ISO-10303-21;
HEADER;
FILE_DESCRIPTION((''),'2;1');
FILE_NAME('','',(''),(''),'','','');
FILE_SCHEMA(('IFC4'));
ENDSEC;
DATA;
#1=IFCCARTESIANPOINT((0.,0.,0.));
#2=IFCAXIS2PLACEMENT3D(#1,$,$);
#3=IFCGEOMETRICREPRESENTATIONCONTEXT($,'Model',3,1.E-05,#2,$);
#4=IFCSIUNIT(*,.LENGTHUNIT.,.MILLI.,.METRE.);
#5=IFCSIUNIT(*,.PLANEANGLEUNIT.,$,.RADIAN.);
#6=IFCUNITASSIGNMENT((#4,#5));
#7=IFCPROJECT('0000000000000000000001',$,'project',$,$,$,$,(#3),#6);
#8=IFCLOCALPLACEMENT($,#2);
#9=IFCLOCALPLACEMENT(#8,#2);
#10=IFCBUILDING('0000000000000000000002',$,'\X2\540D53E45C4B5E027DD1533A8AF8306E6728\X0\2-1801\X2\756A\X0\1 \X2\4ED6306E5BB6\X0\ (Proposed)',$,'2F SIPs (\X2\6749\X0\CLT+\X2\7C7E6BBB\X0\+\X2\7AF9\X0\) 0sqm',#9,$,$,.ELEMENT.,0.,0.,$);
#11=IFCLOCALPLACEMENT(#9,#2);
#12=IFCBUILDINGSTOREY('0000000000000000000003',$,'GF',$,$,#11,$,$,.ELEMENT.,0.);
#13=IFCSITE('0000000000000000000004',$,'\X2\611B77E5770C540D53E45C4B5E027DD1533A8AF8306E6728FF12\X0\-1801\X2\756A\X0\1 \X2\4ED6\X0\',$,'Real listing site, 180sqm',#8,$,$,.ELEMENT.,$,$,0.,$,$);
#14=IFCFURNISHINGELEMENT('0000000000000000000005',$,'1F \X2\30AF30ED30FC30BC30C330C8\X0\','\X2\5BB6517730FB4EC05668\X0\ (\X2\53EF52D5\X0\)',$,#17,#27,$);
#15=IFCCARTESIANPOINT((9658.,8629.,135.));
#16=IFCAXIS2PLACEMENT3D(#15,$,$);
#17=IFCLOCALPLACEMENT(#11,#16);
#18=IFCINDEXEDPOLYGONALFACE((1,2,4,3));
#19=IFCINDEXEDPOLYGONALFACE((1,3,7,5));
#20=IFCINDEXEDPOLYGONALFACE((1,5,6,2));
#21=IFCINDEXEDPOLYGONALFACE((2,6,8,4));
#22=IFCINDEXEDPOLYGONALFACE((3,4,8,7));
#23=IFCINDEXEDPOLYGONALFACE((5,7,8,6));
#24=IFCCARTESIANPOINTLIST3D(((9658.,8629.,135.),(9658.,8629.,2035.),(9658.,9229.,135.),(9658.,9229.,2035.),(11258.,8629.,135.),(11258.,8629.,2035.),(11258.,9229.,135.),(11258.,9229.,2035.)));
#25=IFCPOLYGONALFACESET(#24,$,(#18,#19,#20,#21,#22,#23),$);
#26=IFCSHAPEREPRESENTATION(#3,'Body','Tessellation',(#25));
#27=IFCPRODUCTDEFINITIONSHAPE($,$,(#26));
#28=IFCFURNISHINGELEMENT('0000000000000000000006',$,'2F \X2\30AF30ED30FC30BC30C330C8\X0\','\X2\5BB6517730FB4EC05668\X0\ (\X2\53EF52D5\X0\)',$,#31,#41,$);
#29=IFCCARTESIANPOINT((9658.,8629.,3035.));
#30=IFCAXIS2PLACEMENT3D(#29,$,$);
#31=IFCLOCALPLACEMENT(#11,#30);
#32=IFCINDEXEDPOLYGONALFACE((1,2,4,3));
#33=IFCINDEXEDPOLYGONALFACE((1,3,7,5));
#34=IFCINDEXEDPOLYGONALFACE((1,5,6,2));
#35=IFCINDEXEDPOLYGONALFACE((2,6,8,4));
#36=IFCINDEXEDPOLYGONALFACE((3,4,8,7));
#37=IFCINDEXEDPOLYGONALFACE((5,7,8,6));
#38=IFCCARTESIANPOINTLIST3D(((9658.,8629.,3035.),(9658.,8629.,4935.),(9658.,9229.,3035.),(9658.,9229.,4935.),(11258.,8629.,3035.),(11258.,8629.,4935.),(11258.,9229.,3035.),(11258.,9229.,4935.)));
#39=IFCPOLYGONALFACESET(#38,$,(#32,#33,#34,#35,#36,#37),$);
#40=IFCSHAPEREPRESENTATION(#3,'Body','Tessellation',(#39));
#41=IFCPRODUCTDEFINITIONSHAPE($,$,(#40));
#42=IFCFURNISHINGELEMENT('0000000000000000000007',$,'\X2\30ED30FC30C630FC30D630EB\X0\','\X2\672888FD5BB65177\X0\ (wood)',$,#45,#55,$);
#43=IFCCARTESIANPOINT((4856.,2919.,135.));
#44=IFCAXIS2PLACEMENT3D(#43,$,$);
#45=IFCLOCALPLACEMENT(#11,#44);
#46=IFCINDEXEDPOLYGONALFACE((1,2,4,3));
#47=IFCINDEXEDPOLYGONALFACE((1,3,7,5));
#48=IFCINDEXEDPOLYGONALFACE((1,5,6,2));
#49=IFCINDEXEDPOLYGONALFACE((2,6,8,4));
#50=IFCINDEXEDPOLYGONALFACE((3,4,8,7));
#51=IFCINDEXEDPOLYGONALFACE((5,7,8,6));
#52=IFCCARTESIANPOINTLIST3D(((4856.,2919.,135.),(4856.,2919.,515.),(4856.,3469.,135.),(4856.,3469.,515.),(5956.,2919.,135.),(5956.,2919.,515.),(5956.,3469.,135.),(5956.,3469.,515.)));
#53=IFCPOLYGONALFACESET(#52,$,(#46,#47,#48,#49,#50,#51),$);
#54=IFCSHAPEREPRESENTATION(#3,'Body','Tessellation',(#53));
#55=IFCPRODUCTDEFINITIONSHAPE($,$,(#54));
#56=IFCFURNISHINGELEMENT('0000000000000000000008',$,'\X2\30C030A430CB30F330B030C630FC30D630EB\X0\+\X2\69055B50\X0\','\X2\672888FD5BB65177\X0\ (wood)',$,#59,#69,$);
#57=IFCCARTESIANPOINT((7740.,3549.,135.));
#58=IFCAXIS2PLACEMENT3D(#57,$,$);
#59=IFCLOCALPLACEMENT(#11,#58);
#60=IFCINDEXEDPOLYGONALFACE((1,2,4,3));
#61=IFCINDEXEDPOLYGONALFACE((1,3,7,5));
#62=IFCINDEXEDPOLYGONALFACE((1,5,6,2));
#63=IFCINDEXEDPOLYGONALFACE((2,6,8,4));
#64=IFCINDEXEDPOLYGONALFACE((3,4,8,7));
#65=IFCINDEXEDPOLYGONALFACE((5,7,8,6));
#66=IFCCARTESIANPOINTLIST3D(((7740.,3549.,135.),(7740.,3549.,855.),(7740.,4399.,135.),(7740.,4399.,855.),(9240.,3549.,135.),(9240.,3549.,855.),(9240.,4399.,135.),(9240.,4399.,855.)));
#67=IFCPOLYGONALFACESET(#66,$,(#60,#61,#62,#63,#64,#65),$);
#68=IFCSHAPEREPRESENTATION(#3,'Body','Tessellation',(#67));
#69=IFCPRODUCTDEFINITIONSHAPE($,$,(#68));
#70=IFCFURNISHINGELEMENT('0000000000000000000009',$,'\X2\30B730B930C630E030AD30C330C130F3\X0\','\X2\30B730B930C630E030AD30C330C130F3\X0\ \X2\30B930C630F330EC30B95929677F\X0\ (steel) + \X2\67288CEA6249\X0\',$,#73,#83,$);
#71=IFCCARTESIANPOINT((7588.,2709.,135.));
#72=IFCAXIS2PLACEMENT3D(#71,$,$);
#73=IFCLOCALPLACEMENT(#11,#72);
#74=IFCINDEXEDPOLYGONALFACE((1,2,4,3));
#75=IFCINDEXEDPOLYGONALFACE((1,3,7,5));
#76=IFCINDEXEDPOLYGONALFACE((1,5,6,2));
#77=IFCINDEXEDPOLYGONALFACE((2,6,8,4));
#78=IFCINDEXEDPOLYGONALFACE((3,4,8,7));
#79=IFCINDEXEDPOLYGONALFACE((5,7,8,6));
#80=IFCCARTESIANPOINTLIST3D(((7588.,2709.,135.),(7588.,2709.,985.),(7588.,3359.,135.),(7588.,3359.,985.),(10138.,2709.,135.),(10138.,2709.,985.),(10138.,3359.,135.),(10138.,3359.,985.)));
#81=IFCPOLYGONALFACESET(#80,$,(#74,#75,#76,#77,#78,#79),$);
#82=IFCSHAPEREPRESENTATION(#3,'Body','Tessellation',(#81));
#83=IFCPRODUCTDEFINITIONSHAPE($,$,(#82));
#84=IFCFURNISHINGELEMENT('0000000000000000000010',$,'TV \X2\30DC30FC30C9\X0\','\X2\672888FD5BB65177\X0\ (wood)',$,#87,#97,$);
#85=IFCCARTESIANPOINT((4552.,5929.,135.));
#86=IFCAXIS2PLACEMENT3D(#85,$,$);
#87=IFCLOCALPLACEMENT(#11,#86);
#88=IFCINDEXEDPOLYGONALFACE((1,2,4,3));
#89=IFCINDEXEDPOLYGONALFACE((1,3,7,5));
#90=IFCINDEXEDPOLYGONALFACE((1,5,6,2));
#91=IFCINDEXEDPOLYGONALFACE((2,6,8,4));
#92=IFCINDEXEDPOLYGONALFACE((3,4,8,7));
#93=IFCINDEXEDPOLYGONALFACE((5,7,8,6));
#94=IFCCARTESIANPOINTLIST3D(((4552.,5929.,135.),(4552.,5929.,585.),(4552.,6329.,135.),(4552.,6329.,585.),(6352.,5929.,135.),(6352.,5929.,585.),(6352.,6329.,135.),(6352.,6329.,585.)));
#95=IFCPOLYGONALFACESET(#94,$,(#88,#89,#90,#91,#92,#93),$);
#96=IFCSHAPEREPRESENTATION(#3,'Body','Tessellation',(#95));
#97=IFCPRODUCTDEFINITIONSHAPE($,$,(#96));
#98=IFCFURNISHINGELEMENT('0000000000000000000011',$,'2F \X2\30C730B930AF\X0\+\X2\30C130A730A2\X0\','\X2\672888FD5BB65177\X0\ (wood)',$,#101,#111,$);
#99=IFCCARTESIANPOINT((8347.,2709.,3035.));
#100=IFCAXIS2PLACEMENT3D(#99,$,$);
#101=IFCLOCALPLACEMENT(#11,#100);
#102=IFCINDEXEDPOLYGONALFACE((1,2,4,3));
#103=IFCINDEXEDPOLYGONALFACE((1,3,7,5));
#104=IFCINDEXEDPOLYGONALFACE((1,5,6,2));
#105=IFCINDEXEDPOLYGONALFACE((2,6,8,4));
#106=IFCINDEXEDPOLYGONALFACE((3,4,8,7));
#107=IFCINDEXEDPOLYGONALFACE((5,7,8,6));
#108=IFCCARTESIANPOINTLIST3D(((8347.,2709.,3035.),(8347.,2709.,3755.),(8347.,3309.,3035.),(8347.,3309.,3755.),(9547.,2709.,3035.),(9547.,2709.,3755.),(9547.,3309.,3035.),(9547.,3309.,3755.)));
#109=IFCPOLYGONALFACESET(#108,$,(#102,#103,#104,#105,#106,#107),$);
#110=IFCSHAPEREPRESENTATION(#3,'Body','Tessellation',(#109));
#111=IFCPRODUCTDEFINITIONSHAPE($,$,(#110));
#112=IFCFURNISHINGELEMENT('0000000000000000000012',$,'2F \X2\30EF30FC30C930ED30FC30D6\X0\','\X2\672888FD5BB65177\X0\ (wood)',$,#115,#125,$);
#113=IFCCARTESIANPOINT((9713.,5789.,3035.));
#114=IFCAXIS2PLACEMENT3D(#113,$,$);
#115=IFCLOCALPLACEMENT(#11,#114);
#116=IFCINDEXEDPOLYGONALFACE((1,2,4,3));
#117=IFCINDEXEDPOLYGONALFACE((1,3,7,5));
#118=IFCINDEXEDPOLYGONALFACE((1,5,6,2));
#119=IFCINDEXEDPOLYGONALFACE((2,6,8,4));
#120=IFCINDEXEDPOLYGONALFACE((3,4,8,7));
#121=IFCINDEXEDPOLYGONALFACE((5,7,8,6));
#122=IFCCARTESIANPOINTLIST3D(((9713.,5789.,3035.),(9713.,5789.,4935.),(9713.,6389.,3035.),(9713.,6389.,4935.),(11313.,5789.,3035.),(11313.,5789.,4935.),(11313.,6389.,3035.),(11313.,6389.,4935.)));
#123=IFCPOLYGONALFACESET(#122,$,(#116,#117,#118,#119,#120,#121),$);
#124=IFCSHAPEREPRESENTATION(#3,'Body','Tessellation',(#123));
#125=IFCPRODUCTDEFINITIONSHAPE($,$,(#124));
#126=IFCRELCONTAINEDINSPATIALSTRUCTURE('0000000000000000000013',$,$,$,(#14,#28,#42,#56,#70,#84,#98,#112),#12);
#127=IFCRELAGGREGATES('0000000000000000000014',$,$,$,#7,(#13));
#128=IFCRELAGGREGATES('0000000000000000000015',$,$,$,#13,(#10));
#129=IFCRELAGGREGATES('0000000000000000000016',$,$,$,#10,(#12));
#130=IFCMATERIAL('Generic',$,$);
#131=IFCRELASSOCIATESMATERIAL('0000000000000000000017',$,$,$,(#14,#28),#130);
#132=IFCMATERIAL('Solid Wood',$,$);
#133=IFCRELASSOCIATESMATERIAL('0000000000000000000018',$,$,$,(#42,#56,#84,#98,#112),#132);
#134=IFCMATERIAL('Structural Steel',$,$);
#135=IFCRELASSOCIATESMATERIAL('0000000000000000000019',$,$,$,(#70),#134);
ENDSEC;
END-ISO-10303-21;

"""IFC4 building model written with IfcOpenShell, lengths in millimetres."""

from ifc_helpers import new_model, si_unit, frame, frame_2d, origin, place, context, project, spatial, rectangle, extrude, material, element, save


model = new_model("IFC4")

# Units and contexts
model_context = context("Model", 3, precision=1e-05, world=origin())
ifc_project = project(units=[si_unit("LENGTHUNIT", "METRE", prefix="MILLI"), si_unit("PLANEANGLEUNIT", "RADIAN")], contexts=[model_context])

# Site, building, storey
site_placement = place(None, origin())
site = spatial("IfcSite", under=ifc_project, at=site_placement, Name="愛知県名古屋市緑区諸の木２-1801番1 他", ObjectType="Real listing site, 180sqm", CompositionType="ELEMENT", RefElevation=0.0)
building_placement = place(site_placement, origin())
building = spatial("IfcBuilding", under=site, at=building_placement, Name="名古屋市緑区諸の木2-1801番1 他の家 (Proposed)", ObjectType="2F SIPs (杉CLT+籾殻+竹) 0sqm", CompositionType="ELEMENT", ElevationOfRefHeight=0.0, ElevationOfTerrain=0.0)
storey_placement = place(building_placement, origin())
storey = spatial("IfcBuildingStorey", under=building, at=storey_placement, Name="GF", CompositionType="ELEMENT", Elevation=0.0)

# Shared definitions
ifc_material_1 = material(Name="Solid Wood")

# Shared definitions
ifc_material_2 = material(Name="Generic")

# Furnishing elements
furnishing_1_placement = place(storey_placement, frame((9658.0, 8629.0, 135.0)))
element("IfcFurnishingElement", 1, at=furnishing_1_placement, inside=storey, material=ifc_material_2, Name="1F クローゼット", Description="家具・什器 (可動)", context=model_context, shape_type="SweptSolid", body=[
    extrude(rectangle(XDim=1600.0, YDim=600.0, at=frame_2d((800.0, 300.0))), frame((9658.0, 8629.0, 135.0)), (0.0, 0.0, 1.0), 1900.0),
])
furnishing_2_placement = place(storey_placement, frame((9658.0, 8629.0, 3035.0)))
element("IfcFurnishingElement", 2, at=furnishing_2_placement, inside=storey, material=ifc_material_2, Name="2F クローゼット", Description="家具・什器 (可動)", context=model_context, shape_type="SweptSolid", body=[
    extrude(rectangle(XDim=1600.0, YDim=600.0, at=frame_2d((800.0, 300.0))), frame((9658.0, 8629.0, 3035.0)), (0.0, 0.0, 1.0), 1900.0),
])
furnishing_3_placement = place(storey_placement, frame((4856.0, 2919.0, 135.0)))
element("IfcFurnishingElement", 3, at=furnishing_3_placement, inside=storey, material=ifc_material_1, Name="ローテーブル", Description="木製家具 (wood)", context=model_context, shape_type="SweptSolid", body=[
    extrude(rectangle(XDim=1100.0, YDim=550.0, at=frame_2d((550.0, 275.0))), frame((4856.0, 2919.0, 135.0)), (0.0, 0.0, 1.0), 380.0),
])
furnishing_4_placement = place(storey_placement, frame((7740.0, 3549.0, 135.0)))
element("IfcFurnishingElement", 4, at=furnishing_4_placement, inside=storey, material=ifc_material_1, Name="ダイニングテーブル+椅子", Description="木製家具 (wood)", context=model_context, shape_type="SweptSolid", body=[
    extrude(rectangle(XDim=1500.0, YDim=850.0, at=frame_2d((750.0, 425.0))), frame((7740.0, 3549.0, 135.0)), (0.0, 0.0, 1.0), 720.0),
])
ifc_material_3 = material(Name="Structural Steel")
furnishing_5_placement = place(storey_placement, frame((7588.0, 2709.0, 135.0)))
element("IfcFurnishingElement", 5, at=furnishing_5_placement, inside=storey, material=ifc_material_3, Name="システムキッチン", Description="システムキッチン ステンレス天板 (steel) + 木質扉", context=model_context, shape_type="SweptSolid", body=[
    extrude(rectangle(XDim=2550.0, YDim=650.0, at=frame_2d((1275.0, 325.0))), frame((7588.0, 2709.0, 135.0)), (0.0, 0.0, 1.0), 850.0),
])
furnishing_6_placement = place(storey_placement, frame((4552.0, 5929.0, 135.0)))
element("IfcFurnishingElement", 6, at=furnishing_6_placement, inside=storey, material=ifc_material_1, Name="TV ボード", Description="木製家具 (wood)", context=model_context, shape_type="SweptSolid", body=[
    extrude(rectangle(XDim=1800.0, YDim=400.0, at=frame_2d((900.0, 200.0))), frame((4552.0, 5929.0, 135.0)), (0.0, 0.0, 1.0), 450.0),
])
furnishing_7_placement = place(storey_placement, frame((8347.0, 2709.0, 3035.0)))
element("IfcFurnishingElement", 7, at=furnishing_7_placement, inside=storey, material=ifc_material_1, Name="2F デスク+チェア", Description="木製家具 (wood)", context=model_context, shape_type="SweptSolid", body=[
    extrude(rectangle(XDim=1200.0, YDim=600.0, at=frame_2d((600.0, 300.0))), frame((8347.0, 2709.0, 3035.0)), (0.0, 0.0, 1.0), 720.0),
])
furnishing_8_placement = place(storey_placement, frame((9713.0, 5789.0, 3035.0)))
element("IfcFurnishingElement", 8, at=furnishing_8_placement, inside=storey, material=ifc_material_1, Name="2F ワードローブ", Description="木製家具 (wood)", context=model_context, shape_type="SweptSolid", body=[
    extrude(rectangle(XDim=1600.0, YDim=600.0, at=frame_2d((800.0, 300.0))), frame((9713.0, 5789.0, 3035.0)), (0.0, 0.0, 1.0), 1900.0),
])

save(model, "model.ifc")
